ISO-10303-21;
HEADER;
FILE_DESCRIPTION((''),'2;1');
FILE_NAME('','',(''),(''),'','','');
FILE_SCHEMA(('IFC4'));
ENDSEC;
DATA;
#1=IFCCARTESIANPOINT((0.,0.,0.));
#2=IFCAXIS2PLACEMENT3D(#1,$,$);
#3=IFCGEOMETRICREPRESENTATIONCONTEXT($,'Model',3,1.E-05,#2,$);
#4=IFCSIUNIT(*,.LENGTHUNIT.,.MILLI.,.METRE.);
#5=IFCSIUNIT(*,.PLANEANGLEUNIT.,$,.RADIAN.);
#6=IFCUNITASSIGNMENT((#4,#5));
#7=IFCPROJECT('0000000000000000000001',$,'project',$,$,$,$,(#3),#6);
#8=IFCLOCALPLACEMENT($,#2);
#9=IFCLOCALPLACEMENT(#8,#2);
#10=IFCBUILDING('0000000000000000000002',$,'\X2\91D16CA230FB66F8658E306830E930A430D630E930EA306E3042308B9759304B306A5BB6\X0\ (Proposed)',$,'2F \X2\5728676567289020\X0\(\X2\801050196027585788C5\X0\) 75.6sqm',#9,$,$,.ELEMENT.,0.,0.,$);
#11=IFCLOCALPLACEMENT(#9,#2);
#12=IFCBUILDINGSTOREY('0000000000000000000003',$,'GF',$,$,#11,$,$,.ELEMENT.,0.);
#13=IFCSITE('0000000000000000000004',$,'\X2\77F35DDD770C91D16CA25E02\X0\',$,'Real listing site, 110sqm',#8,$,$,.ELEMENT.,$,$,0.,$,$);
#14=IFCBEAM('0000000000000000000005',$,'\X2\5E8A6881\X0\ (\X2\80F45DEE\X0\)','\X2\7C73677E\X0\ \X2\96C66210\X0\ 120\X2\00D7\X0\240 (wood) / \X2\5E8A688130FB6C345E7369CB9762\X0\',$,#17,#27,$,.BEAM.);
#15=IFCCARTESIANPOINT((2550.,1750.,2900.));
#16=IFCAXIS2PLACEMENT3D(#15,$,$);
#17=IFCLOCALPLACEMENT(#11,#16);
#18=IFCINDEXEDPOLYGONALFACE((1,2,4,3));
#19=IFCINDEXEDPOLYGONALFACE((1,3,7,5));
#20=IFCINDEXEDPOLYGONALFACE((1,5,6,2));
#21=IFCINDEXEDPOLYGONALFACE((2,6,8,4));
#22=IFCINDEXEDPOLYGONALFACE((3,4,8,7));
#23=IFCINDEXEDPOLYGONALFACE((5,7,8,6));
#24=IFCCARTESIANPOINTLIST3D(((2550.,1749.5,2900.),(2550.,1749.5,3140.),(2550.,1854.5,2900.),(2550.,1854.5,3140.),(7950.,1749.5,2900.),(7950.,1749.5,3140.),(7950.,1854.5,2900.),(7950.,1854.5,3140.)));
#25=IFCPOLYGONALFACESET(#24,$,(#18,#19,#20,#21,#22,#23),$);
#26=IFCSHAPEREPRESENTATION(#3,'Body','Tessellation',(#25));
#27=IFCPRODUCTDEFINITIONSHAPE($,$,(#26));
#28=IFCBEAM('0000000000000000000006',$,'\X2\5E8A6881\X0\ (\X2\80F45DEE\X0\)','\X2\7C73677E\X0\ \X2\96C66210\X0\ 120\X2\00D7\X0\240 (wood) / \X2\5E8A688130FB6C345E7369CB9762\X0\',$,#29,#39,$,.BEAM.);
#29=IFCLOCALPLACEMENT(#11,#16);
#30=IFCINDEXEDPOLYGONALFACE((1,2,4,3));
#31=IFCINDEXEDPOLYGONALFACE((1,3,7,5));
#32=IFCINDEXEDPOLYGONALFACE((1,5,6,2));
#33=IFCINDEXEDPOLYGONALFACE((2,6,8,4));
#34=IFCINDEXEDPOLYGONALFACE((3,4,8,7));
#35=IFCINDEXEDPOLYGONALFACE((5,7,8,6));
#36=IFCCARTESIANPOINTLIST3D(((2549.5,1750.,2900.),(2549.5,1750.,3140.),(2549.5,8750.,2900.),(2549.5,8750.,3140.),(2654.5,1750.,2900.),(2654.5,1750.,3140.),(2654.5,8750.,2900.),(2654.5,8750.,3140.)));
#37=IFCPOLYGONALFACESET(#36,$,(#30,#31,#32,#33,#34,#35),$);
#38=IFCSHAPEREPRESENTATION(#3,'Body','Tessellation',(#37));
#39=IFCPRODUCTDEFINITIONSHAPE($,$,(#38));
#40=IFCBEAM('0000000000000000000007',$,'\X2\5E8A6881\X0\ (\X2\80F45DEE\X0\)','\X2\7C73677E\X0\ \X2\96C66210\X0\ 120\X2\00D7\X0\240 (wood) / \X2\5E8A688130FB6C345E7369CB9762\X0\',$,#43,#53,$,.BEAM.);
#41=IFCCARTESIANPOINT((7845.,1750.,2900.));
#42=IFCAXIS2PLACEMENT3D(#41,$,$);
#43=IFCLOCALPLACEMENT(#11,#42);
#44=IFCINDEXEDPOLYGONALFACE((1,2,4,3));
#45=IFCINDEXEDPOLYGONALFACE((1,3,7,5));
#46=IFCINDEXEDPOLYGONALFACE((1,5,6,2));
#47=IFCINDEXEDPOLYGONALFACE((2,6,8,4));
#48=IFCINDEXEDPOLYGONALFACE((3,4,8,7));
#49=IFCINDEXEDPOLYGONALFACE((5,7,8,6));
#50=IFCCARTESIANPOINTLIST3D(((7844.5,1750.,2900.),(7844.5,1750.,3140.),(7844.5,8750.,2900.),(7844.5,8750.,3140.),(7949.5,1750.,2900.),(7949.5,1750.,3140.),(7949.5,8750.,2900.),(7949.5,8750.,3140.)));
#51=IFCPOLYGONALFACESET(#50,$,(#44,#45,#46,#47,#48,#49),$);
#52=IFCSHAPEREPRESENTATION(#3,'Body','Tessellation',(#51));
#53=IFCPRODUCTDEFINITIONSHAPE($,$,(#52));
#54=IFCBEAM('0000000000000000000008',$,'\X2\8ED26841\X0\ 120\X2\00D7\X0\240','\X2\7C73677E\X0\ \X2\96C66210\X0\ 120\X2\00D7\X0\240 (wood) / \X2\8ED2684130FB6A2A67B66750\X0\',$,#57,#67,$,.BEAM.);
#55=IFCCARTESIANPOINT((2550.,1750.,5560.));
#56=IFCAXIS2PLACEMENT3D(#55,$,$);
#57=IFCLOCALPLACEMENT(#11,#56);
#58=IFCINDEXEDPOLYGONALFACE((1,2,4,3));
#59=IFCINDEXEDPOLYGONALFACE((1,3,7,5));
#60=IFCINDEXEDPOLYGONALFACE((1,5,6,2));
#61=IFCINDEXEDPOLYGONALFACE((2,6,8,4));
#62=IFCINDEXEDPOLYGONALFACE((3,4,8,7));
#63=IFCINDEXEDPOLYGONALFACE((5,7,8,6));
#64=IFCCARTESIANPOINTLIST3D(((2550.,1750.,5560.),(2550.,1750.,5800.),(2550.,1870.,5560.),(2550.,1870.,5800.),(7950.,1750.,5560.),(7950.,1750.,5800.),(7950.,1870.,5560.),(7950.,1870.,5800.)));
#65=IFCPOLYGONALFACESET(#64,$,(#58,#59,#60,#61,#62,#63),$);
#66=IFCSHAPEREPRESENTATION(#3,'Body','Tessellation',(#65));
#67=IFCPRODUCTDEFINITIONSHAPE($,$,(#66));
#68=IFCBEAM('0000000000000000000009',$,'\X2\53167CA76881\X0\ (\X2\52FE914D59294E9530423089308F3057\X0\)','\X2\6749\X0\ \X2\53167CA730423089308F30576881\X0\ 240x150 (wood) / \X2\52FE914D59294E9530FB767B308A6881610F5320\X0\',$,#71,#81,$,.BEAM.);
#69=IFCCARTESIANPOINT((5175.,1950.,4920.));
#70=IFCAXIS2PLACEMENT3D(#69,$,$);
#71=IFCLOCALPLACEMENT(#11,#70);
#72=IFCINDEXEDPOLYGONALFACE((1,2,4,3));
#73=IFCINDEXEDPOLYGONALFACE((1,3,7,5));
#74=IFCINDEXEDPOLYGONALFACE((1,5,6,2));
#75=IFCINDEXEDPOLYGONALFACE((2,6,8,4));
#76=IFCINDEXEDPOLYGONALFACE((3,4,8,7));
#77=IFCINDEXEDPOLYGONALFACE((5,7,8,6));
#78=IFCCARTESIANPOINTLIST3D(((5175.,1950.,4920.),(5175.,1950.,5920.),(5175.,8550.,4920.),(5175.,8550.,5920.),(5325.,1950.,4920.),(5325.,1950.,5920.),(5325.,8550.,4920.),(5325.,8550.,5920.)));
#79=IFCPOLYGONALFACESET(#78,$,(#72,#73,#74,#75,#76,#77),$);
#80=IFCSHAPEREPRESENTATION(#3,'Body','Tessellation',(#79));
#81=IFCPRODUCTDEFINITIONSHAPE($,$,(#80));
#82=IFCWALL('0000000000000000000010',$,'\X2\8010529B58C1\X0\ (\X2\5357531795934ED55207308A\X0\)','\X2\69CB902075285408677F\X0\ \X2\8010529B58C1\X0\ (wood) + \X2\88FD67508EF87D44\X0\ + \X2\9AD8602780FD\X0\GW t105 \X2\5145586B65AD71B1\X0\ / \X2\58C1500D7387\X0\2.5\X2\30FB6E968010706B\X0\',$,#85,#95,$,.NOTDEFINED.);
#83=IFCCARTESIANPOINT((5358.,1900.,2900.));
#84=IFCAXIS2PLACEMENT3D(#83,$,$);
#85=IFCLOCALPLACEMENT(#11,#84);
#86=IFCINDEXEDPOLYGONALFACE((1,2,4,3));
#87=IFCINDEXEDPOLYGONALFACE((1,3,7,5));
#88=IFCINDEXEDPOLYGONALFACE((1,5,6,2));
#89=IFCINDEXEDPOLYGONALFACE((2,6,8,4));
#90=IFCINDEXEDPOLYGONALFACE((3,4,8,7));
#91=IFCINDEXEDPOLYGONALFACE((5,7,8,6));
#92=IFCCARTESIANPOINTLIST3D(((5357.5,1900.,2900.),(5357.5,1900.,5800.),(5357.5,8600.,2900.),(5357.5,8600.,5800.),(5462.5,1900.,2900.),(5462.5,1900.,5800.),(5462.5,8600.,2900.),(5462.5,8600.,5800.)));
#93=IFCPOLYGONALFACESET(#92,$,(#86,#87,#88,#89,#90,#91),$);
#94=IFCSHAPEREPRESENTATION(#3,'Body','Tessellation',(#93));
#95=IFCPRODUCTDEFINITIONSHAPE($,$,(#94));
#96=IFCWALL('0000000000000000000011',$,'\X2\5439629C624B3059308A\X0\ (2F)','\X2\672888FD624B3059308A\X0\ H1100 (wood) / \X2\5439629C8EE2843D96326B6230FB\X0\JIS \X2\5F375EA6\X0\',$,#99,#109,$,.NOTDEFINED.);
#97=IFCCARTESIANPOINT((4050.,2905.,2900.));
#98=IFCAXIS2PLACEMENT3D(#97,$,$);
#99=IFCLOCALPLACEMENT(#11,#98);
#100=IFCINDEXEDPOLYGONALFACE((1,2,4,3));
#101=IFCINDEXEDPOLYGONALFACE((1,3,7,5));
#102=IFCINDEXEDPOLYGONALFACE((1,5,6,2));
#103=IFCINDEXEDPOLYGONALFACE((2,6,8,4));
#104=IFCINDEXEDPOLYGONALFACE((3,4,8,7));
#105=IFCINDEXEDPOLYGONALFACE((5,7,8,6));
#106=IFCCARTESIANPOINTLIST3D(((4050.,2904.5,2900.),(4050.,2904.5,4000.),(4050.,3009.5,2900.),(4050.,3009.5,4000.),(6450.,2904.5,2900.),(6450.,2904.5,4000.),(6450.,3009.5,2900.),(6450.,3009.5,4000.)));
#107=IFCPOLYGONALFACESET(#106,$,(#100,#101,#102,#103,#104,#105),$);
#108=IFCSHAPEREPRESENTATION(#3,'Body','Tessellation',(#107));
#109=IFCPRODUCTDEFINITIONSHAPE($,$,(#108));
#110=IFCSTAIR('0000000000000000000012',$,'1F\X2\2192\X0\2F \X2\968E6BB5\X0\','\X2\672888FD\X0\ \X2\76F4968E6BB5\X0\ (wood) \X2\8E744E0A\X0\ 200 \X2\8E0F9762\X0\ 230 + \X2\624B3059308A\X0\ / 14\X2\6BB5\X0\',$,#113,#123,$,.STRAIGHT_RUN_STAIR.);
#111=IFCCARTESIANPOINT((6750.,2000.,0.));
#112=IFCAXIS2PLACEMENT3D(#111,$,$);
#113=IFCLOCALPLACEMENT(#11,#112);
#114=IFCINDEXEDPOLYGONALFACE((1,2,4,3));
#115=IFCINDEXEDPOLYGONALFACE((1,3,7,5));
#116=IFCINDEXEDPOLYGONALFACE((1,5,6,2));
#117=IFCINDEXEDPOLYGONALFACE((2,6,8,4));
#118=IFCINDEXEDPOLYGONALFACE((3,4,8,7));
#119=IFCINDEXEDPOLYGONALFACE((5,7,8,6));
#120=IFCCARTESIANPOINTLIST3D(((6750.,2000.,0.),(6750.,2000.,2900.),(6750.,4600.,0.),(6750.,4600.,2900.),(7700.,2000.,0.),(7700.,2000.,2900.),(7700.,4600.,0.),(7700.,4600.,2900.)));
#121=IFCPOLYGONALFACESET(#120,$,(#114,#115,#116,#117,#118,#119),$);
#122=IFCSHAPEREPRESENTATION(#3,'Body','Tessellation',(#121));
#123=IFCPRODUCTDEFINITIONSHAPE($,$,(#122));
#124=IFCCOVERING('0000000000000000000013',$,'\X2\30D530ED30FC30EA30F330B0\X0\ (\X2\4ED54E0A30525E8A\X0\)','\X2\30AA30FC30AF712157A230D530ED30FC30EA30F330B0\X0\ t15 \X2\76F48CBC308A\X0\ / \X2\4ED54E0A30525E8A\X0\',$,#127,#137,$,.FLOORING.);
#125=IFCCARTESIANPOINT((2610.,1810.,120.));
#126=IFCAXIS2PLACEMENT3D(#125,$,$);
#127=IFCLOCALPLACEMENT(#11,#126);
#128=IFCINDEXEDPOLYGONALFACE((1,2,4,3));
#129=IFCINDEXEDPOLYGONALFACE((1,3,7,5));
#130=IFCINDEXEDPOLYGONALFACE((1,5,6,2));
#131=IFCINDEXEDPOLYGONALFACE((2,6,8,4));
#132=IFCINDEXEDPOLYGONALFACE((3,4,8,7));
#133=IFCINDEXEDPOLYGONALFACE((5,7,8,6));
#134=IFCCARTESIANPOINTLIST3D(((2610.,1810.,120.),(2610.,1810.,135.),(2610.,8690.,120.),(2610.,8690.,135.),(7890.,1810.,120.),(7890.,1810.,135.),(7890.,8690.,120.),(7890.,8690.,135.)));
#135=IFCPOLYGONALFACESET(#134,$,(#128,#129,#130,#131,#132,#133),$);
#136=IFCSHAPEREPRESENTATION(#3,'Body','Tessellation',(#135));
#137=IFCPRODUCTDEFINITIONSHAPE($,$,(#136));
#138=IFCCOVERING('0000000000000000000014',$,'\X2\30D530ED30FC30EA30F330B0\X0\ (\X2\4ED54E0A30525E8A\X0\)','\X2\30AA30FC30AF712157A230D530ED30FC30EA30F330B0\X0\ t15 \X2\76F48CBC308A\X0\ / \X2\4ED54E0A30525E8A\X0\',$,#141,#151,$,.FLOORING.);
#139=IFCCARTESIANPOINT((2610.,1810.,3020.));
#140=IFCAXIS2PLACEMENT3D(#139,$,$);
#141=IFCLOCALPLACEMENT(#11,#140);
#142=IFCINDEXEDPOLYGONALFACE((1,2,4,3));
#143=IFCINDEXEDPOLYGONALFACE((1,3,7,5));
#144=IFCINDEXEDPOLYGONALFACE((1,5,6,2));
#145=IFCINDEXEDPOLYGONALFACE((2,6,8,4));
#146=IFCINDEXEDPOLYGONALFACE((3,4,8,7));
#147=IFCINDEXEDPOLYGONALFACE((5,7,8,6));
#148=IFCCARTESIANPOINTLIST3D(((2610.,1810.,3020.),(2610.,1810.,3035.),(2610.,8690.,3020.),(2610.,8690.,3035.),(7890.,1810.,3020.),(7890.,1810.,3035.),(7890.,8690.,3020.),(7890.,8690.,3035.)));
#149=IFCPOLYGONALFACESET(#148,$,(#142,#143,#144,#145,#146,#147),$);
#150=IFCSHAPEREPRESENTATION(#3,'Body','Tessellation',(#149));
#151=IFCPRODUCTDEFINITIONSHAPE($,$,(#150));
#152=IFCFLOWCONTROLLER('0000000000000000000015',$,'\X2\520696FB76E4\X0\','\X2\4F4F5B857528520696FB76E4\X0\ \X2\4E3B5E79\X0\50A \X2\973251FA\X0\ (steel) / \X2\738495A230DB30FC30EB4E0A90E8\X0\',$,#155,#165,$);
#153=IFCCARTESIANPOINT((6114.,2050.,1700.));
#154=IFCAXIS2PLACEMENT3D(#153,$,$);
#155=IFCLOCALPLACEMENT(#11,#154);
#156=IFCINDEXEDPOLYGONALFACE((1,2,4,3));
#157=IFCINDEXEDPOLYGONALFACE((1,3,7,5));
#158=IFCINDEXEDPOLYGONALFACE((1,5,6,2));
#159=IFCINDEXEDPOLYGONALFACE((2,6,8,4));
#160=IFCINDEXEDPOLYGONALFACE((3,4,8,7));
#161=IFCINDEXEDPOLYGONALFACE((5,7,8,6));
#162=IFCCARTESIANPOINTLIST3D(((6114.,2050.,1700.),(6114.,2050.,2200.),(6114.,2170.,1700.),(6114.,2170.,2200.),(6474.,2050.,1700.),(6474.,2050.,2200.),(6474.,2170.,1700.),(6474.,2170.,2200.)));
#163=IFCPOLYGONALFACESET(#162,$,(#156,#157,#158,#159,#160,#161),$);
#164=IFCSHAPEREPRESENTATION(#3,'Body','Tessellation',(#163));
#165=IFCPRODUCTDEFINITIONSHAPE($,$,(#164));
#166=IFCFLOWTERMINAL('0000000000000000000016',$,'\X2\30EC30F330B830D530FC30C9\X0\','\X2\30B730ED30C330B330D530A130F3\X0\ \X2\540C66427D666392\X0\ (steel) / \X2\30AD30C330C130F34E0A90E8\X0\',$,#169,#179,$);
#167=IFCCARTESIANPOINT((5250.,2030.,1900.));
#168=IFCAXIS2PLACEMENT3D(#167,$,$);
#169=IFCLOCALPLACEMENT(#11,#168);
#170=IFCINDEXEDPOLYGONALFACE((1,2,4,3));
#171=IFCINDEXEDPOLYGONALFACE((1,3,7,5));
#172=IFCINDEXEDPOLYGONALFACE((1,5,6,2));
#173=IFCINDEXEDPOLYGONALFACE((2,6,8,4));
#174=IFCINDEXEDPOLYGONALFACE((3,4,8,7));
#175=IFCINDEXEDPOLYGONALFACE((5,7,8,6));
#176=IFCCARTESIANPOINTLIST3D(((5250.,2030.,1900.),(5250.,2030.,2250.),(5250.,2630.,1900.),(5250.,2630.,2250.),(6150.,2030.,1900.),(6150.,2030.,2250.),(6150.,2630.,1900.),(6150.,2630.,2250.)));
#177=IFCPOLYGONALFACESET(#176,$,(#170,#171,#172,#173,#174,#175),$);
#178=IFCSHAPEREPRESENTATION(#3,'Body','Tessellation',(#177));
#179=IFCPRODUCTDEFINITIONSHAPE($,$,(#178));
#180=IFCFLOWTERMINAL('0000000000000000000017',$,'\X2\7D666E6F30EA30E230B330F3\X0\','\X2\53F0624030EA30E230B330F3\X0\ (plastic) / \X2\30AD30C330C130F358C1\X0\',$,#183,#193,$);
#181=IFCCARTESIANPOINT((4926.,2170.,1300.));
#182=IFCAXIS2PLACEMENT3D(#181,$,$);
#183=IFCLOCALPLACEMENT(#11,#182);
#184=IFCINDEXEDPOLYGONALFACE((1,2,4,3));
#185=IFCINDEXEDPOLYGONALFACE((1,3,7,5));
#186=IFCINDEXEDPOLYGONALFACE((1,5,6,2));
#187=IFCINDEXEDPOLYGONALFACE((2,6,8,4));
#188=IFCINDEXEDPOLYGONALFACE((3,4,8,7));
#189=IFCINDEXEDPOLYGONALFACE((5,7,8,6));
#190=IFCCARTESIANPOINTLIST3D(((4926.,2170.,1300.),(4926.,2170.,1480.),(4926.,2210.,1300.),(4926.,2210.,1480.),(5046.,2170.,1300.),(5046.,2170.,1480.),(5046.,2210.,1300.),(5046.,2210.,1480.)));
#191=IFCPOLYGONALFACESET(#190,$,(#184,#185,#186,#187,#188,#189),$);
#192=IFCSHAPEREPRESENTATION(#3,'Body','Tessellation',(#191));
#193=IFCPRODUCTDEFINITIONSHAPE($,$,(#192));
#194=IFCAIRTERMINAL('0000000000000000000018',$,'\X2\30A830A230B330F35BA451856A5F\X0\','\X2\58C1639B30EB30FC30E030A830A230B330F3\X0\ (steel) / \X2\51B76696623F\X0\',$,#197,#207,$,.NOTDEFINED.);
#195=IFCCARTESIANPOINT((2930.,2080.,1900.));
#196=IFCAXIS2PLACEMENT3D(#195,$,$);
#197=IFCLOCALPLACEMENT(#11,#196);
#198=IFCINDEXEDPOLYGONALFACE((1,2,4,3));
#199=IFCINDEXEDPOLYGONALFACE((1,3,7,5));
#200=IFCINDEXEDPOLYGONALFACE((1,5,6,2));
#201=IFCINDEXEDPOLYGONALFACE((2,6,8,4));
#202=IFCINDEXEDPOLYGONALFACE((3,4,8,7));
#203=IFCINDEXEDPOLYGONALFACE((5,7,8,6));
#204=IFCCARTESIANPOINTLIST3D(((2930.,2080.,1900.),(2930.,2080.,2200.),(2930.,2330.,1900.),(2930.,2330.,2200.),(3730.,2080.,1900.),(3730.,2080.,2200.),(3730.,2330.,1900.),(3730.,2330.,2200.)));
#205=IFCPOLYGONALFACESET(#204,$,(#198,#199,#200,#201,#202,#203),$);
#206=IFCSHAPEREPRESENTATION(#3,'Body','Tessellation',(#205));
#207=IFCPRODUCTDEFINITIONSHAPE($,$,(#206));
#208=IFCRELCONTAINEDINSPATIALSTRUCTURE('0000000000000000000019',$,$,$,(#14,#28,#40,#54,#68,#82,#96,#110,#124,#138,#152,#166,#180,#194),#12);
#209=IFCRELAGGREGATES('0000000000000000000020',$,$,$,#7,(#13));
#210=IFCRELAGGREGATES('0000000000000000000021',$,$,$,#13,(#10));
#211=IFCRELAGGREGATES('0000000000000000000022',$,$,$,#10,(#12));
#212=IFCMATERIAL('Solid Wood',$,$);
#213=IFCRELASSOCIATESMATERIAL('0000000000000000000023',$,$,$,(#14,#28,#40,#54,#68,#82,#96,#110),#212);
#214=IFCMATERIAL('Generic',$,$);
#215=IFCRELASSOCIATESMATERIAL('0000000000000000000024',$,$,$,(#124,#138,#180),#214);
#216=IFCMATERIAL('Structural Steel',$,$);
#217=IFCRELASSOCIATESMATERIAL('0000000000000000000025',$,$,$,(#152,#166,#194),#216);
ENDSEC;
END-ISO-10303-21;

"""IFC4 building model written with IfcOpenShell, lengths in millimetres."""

from ifc_helpers import new_model, si_unit, frame, frame_2d, origin, place, context, project, spatial, rectangle, extrude, material, element, save


model = new_model("IFC4")

# Units and contexts
model_context = context("Model", 3, precision=1e-05, world=origin())
ifc_project = project(units=[si_unit("LENGTHUNIT", "METRE", prefix="MILLI"), si_unit("PLANEANGLEUNIT", "RADIAN")], contexts=[model_context])

# Site, building, storey
site_placement = place(None, origin())
site = spatial("IfcSite", under=ifc_project, at=site_placement, Name="石川県金沢市", ObjectType="Real listing site, 110sqm", CompositionType="ELEMENT", RefElevation=0.0)
building_placement = place(site_placement, origin())
building = spatial("IfcBuilding", under=site, at=building_placement, Name="金沢・書斎とライブラリのある静かな家 (Proposed)", ObjectType="2F 在来木造(耐候性塗装) 75.6sqm", CompositionType="ELEMENT", ElevationOfRefHeight=0.0, ElevationOfTerrain=0.0)
storey_placement = place(building_placement, origin())
storey = spatial("IfcBuildingStorey", under=building, at=storey_placement, Name="GF", CompositionType="ELEMENT", Elevation=0.0)

# Shared definitions
ifc_material_1 = material(Name="Solid Wood")

# Beams
beam_1_placement = place(storey_placement, frame((2550.0, 1750.0, 2900.0)))
element("IfcBeam", 1, at=beam_1_placement, inside=storey, material=ifc_material_1, Name="床梁 (胴差)", Description="米松 集成 120×240 (wood) / 床梁・水平構面", PredefinedType="BEAM", context=model_context, shape_type="SweptSolid", body=[
    extrude(rectangle(XDim=5400.0, YDim=105.0, at=frame_2d((2700.0, 52.0))), frame((2550.0, 1750.0, 2900.0)), (0.0, 0.0, 1.0), 240.0),
])
beam_2_placement = place(storey_placement, frame((2550.0, 1750.0, 2900.0)))
element("IfcBeam", 2, at=beam_2_placement, inside=storey, material=ifc_material_1, Name="床梁 (胴差)", Description="米松 集成 120×240 (wood) / 床梁・水平構面", PredefinedType="BEAM", context=model_context, shape_type="SweptSolid", body=[
    extrude(rectangle(XDim=105.0, YDim=7000.0, at=frame_2d((52.0, 3500.0))), frame((2550.0, 1750.0, 2900.0)), (0.0, 0.0, 1.0), 240.0),
])
beam_3_placement = place(storey_placement, frame((7845.0, 1750.0, 2900.0)))
element("IfcBeam", 3, at=beam_3_placement, inside=storey, material=ifc_material_1, Name="床梁 (胴差)", Description="米松 集成 120×240 (wood) / 床梁・水平構面", PredefinedType="BEAM", context=model_context, shape_type="SweptSolid", body=[
    extrude(rectangle(XDim=105.0, YDim=7000.0, at=frame_2d((52.0, 3500.0))), frame((7845.0, 1750.0, 2900.0)), (0.0, 0.0, 1.0), 240.0),
])
beam_4_placement = place(storey_placement, frame((2550.0, 1750.0, 5560.0)))
element("IfcBeam", 4, at=beam_4_placement, inside=storey, material=ifc_material_1, Name="軒桁 120×240", Description="米松 集成 120×240 (wood) / 軒桁・横架材", PredefinedType="BEAM", context=model_context, shape_type="SweptSolid", body=[
    extrude(rectangle(XDim=5400.0, YDim=120.0, at=frame_2d((2700.0, 60.0))), frame((2550.0, 1750.0, 5560.0)), (0.0, 0.0, 1.0), 240.0),
])
beam_5_placement = place(storey_placement, frame((5175.0, 1950.0, 4920.0)))
element("IfcBeam", 5, at=beam_5_placement, inside=storey, material=ifc_material_1, Name="化粧梁 (勾配天井あらわし)", Description="杉 化粧あらわし梁 240x150 (wood) / 勾配天井・登り梁意匠", PredefinedType="BEAM", context=model_context, shape_type="SweptSolid", body=[
    extrude(rectangle(XDim=150.0, YDim=6600.0, at=frame_2d((75.0, 3300.0))), frame((5175.0, 1950.0, 4920.0)), (0.0, 0.0, 1.0), 1000.0),
])

# Walls
wall_1_placement = place(storey_placement, frame((5358.0, 1900.0, 2900.0)))
element("IfcWall", 6, at=wall_1_placement, inside=storey, material=ifc_material_1, Name="耐力壁 (南北間仕切り)", Description="構造用合板 耐力壁 (wood) + 製材軸組 + 高性能GW t105 充填断熱 / 壁倍率2.5・準耐火", PredefinedType="NOTDEFINED", context=model_context, shape_type="SweptSolid", body=[
    extrude(rectangle(XDim=105.0, YDim=6700.0, at=frame_2d((52.0, 3350.0))), frame((5358.0, 1900.0, 2900.0)), (0.0, 0.0, 1.0), 2900.0),
])
wall_2_placement = place(storey_placement, frame((4050.0, 2905.0, 2900.0)))
element("IfcWall", 7, at=wall_2_placement, inside=storey, material=ifc_material_1, Name="吹抜手すり (2F)", Description="木製手すり H1100 (wood) / 吹抜転落防止・JIS 強度", PredefinedType="NOTDEFINED", context=model_context, shape_type="SweptSolid", body=[
    extrude(rectangle(XDim=2400.0, YDim=105.0, at=frame_2d((1200.0, 52.0))), frame((4050.0, 2905.0, 2900.0)), (0.0, 0.0, 1.0), 1100.0),
])

# Stair
stair_placement = place(storey_placement, frame((6750.0, 2000.0, 0.0)))
element("IfcStair", 8, at=stair_placement, inside=storey, material=ifc_material_1, Name="1F→2F 階段", Description="木製 直階段 (wood) 蹴上 200 踏面 230 + 手すり / 14段", PredefinedType="STRAIGHT_RUN_STAIR", context=model_context, shape_type="SweptSolid", body=[
    extrude(rectangle(XDim=950.0, YDim=2600.0, at=frame_2d((475.0, 1300.0))), frame((6750.0, 2000.0, 0.0)), (0.0, 0.0, 1.0), 2900.0),
])

# Coverings
ifc_material_2 = material(Name="Generic")
covering_1_placement = place(storey_placement, frame((2610.0, 1810.0, 120.0)))
element("IfcCovering", 9, at=covering_1_placement, inside=storey, material=ifc_material_2, Name="フローリング (仕上げ床)", Description="オーク無垢フローリング t15 直貼り / 仕上げ床", PredefinedType="FLOORING", context=model_context, shape_type="SweptSolid", body=[
    extrude(rectangle(XDim=5280.0, YDim=6880.0, at=frame_2d((2640.0, 3440.0))), frame((2610.0, 1810.0, 120.0)), (0.0, 0.0, 1.0), 15.0),
])
covering_2_placement = place(storey_placement, frame((2610.0, 1810.0, 3020.0)))
element("IfcCovering", 10, at=covering_2_placement, inside=storey, material=ifc_material_2, Name="フローリング (仕上げ床)", Description="オーク無垢フローリング t15 直貼り / 仕上げ床", PredefinedType="FLOORING", context=model_context, shape_type="SweptSolid", body=[
    extrude(rectangle(XDim=5280.0, YDim=6880.0, at=frame_2d((2640.0, 3440.0))), frame((2610.0, 1810.0, 3020.0)), (0.0, 0.0, 1.0), 15.0),
])

# Flow controller
ifc_material_3 = material(Name="Structural Steel")
flow_controller_placement = place(storey_placement, frame((6114.0, 2050.0, 1700.0)))
element("IfcFlowController", 11, at=flow_controller_placement, inside=storey, material=ifc_material_3, Name="分電盤", Description="住宅用分電盤 主幹50A 露出 (steel) / 玄関ホール上部", context=model_context, shape_type="SweptSolid", body=[
    extrude(rectangle(XDim=360.0, YDim=120.0, at=frame_2d((180.0, 60.0))), frame((6114.0, 2050.0, 1700.0)), (0.0, 0.0, 1.0), 500.0),
])

# Flow terminals
flow_terminal_1_placement = place(storey_placement, frame((5250.0, 2030.0, 1900.0)))
element("IfcFlowTerminal", 12, at=flow_terminal_1_placement, inside=storey, material=ifc_material_3, Name="レンジフード", Description="シロッコファン 同時給排 (steel) / キッチン上部", context=model_context, shape_type="SweptSolid", body=[
    extrude(rectangle(XDim=900.0, YDim=600.0, at=frame_2d((450.0, 300.0))), frame((5250.0, 2030.0, 1900.0)), (0.0, 0.0, 1.0), 350.0),
])
flow_terminal_2_placement = place(storey_placement, frame((4926.0, 2170.0, 1300.0)))
element("IfcFlowTerminal", 13, at=flow_terminal_2_placement, inside=storey, material=ifc_material_2, Name="給湯リモコン", Description="台所リモコン (plastic) / キッチン壁", context=model_context, shape_type="SweptSolid", body=[
    extrude(rectangle(XDim=120.0, YDim=40.0, at=frame_2d((60.0, 20.0))), frame((4926.0, 2170.0, 1300.0)), (0.0, 0.0, 1.0), 180.0),
])

# Air terminal
air_terminal_1_placement = place(storey_placement, frame((2930.0, 2080.0, 1900.0)))
element("IfcAirTerminal", 14, at=air_terminal_1_placement, inside=storey, material=ifc_material_3, Name="エアコン室内機", Description="壁掛ルームエアコン (steel) / 冷暖房", PredefinedType="NOTDEFINED", context=model_context, shape_type="SweptSolid", body=[
    extrude(rectangle(XDim=800.0, YDim=250.0, at=frame_2d((400.0, 125.0))), frame((2930.0, 2080.0, 1900.0)), (0.0, 0.0, 1.0), 300.0),
])

save(model, "model.ifc")
